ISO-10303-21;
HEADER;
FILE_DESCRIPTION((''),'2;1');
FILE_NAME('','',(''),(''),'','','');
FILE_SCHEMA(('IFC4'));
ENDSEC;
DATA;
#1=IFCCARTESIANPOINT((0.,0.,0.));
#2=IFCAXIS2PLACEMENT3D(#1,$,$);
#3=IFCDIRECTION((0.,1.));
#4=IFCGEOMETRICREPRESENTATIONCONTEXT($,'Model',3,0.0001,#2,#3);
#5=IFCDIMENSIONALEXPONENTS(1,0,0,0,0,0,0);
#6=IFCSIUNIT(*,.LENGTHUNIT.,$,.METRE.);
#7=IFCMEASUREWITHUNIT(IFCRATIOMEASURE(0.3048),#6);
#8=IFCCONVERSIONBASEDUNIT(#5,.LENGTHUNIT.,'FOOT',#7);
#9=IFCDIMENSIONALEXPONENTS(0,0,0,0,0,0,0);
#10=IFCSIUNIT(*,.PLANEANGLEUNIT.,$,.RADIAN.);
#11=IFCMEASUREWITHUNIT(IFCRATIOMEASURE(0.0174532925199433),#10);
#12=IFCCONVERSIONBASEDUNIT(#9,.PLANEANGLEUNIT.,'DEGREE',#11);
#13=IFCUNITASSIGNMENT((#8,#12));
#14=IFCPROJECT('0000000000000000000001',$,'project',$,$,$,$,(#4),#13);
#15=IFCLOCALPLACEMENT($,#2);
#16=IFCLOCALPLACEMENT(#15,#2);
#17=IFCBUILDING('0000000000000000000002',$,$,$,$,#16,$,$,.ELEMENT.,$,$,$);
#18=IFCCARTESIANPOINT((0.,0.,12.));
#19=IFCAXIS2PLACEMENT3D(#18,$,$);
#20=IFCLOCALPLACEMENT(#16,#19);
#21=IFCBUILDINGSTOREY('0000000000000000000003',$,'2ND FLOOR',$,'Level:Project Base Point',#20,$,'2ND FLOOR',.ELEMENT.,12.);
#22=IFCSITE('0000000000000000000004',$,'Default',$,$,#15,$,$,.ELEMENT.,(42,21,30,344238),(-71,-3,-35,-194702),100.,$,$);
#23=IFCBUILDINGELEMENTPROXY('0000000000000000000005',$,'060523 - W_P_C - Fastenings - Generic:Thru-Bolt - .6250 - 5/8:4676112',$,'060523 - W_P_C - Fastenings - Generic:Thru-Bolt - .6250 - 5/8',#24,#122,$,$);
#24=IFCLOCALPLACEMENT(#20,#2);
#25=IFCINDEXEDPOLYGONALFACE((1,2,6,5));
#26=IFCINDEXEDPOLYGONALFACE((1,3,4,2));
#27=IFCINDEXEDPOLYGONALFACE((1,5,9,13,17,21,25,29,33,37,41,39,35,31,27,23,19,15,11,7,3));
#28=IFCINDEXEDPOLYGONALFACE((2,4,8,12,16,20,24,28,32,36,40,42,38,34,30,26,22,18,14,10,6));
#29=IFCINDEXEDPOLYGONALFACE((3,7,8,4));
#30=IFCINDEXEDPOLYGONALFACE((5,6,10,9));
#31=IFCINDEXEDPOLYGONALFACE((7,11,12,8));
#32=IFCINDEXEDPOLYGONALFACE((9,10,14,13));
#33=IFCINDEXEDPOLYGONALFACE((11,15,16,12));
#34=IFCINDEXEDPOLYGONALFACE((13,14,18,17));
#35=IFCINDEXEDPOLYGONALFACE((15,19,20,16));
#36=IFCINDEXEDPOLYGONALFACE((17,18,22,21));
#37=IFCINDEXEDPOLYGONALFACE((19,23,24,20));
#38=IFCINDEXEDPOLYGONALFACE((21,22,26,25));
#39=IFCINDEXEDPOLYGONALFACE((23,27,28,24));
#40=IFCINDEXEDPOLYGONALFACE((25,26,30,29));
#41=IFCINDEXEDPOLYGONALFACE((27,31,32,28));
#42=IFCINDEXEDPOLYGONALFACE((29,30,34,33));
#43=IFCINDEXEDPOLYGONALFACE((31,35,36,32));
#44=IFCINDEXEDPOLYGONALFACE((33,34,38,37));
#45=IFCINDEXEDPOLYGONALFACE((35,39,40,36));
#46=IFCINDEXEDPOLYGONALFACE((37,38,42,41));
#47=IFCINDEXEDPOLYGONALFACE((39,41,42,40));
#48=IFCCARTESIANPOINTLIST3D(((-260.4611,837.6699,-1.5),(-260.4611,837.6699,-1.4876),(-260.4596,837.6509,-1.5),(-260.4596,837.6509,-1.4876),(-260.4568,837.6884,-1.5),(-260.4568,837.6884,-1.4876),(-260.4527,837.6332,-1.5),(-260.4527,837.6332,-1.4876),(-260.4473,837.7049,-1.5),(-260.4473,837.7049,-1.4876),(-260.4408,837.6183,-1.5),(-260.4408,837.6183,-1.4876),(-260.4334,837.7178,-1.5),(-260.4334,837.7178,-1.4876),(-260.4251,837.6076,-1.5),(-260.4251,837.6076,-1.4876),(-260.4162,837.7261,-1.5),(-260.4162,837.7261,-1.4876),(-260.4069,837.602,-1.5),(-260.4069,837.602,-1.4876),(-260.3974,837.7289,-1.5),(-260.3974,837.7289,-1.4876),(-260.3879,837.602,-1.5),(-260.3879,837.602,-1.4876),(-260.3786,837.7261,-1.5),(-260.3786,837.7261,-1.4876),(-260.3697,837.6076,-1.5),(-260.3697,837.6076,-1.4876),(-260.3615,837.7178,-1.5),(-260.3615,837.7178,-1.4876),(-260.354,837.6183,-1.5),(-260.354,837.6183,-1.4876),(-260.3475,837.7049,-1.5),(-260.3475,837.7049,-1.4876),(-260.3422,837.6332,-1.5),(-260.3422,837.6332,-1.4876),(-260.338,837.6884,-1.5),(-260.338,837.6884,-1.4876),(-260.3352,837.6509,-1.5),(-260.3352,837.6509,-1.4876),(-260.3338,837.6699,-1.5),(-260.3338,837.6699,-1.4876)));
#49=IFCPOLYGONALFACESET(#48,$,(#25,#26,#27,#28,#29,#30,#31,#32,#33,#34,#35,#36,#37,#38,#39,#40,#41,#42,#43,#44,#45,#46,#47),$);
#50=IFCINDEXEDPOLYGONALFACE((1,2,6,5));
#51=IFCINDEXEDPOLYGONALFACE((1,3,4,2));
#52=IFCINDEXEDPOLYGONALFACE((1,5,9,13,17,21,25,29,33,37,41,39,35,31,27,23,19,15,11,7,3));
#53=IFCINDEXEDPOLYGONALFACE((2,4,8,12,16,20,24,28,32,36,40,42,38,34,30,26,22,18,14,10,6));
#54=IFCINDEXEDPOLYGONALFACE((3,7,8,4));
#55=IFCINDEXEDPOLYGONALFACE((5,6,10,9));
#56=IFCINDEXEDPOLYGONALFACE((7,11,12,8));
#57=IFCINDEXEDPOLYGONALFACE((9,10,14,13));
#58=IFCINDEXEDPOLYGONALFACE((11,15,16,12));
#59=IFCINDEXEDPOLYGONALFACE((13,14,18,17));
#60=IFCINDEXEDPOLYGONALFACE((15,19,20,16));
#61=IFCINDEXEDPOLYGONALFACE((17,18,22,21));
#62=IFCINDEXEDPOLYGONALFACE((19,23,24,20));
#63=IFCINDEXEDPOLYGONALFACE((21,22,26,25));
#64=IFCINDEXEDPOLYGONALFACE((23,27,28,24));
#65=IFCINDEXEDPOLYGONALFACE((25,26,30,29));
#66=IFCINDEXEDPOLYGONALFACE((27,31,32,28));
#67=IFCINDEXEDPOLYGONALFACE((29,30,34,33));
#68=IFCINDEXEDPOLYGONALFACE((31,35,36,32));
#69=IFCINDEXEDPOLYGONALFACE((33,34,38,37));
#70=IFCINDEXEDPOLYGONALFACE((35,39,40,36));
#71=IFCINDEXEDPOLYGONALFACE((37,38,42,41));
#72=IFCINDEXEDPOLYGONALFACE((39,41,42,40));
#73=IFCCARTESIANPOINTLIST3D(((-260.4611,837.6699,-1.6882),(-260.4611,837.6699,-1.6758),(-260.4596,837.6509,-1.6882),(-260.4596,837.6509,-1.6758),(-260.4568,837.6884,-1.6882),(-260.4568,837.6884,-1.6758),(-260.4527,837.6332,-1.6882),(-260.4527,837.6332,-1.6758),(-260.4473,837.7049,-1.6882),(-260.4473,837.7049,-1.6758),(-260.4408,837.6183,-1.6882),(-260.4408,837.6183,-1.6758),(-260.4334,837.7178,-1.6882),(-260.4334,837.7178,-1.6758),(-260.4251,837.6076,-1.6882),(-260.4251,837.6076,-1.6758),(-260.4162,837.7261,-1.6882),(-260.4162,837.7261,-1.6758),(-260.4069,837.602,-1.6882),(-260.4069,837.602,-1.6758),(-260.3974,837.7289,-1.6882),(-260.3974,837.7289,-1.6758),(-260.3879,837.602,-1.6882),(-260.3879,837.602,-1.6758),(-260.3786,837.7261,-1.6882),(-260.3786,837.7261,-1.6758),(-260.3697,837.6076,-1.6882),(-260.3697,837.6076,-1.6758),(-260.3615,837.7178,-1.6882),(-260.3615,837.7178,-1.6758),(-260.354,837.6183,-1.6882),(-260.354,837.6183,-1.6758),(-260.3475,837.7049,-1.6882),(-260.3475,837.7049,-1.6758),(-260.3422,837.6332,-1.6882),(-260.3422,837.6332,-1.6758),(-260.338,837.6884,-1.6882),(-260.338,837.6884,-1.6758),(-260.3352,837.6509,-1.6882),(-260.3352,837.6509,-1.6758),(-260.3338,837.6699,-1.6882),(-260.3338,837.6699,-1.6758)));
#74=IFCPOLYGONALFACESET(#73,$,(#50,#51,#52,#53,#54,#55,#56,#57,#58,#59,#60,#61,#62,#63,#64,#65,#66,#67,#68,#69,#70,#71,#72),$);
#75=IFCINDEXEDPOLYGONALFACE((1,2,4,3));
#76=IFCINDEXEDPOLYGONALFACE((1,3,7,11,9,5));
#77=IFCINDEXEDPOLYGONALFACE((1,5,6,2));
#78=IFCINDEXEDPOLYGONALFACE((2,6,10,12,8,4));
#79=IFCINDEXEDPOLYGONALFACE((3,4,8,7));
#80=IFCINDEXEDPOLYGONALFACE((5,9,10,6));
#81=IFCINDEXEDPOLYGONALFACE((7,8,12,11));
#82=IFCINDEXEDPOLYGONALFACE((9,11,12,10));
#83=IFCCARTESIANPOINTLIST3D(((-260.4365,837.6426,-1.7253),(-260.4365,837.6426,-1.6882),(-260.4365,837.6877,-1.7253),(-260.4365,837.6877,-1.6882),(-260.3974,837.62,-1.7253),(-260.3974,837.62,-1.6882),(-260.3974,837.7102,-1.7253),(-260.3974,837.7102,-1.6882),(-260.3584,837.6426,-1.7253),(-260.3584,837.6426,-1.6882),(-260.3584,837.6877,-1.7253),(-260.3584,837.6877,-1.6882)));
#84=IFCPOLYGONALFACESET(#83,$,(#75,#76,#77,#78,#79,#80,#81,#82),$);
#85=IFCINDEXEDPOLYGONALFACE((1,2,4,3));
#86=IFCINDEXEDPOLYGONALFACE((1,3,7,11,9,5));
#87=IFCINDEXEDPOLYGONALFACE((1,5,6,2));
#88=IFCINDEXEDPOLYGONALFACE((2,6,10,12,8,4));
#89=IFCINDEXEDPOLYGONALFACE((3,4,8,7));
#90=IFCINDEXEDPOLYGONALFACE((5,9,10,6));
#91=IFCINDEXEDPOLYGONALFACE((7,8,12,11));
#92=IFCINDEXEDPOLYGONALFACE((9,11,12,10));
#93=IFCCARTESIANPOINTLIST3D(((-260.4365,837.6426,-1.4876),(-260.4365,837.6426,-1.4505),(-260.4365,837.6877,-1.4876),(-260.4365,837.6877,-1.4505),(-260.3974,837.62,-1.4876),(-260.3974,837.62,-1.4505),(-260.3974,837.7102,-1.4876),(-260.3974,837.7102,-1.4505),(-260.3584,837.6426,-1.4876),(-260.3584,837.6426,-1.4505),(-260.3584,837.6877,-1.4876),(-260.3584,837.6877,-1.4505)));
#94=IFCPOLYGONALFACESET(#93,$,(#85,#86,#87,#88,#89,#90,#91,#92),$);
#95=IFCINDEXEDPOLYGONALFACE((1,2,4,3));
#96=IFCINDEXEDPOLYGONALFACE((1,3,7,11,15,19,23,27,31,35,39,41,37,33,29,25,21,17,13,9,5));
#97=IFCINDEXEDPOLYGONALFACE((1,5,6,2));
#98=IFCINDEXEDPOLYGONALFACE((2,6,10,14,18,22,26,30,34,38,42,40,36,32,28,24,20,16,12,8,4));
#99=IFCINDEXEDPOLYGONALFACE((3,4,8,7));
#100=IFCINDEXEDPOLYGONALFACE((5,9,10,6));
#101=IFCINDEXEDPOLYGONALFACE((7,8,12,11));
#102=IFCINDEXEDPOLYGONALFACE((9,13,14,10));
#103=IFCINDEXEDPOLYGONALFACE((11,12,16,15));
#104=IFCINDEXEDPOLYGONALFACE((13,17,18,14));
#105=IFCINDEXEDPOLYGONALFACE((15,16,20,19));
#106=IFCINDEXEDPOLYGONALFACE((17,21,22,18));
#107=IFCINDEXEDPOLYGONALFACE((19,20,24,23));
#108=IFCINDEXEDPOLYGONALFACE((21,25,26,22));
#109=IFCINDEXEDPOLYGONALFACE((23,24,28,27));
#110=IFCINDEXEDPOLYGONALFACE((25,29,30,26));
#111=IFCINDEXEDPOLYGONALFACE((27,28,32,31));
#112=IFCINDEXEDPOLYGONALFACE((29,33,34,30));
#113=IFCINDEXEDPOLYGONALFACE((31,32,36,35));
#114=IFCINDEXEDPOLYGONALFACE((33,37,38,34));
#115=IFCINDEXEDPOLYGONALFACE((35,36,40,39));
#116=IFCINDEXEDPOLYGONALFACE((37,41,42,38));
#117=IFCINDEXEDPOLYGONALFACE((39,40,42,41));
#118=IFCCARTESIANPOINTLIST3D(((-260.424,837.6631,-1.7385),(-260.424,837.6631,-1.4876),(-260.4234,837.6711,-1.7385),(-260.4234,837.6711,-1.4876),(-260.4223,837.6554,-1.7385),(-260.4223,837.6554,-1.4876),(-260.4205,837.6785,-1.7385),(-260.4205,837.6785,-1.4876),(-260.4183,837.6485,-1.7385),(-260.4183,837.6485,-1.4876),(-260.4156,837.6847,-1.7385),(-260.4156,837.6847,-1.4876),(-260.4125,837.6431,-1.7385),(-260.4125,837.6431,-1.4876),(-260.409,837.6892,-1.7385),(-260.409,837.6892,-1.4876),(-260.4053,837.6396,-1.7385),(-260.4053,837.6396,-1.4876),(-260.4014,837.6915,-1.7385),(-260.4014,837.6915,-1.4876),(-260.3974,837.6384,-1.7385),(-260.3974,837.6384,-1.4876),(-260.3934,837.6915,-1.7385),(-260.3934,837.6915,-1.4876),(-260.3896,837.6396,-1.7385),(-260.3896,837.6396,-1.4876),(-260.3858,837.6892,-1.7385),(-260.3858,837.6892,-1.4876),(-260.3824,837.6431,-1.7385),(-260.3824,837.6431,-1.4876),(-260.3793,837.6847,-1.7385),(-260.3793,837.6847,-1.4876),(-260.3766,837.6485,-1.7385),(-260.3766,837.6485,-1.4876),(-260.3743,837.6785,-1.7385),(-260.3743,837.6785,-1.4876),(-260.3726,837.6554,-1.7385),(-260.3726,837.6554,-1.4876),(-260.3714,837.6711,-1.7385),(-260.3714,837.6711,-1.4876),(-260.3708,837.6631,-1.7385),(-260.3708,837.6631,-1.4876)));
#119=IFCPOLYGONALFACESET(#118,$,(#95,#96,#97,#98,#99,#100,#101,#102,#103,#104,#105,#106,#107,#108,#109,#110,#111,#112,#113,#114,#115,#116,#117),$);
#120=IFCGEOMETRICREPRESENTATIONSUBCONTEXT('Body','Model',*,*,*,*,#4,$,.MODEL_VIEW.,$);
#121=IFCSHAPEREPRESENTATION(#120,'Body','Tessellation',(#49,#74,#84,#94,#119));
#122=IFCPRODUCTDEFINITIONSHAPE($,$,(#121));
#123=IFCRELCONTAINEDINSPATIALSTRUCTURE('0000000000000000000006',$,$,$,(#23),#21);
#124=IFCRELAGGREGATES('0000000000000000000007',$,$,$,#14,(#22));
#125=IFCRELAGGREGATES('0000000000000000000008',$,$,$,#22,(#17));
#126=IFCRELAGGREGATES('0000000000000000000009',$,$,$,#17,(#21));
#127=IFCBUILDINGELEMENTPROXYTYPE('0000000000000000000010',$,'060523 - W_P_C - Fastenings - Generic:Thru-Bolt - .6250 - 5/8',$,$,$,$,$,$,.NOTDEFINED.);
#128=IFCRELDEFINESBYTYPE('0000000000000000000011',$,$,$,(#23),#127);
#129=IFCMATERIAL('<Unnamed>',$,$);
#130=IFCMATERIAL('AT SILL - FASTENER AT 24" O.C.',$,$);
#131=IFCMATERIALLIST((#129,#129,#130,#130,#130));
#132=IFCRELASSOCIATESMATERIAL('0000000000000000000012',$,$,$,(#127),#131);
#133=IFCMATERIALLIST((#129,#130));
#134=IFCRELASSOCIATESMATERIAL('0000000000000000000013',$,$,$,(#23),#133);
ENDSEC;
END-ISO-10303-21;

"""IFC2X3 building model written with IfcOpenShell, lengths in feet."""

from ifc_helpers import new_model, entity, si_unit, converted_unit, direction, frame, frame_2d, origin, place, context, subcontext, project, spatial, polyline, circle, outline, extrude, source, transform, mapped, material, material_list, type_object, type_shapes, element, save


model = new_model("IFC2X3")

# Units and contexts
model_context = context("Model", 3, precision=0.0001, world=origin(), true_north=direction((0.0, 1.0)))
body_context = subcontext(model_context, "Body", "Model", "MODEL_VIEW")
ifc_project = project(units=[converted_unit("LENGTHUNIT", "FOOT", entity("IfcRatioMeasure", 0.3048), si_unit("LENGTHUNIT", "METRE"), dimensions=[1, 0, 0, 0, 0, 0, 0]), converted_unit("PLANEANGLEUNIT", "DEGREE", entity("IfcRatioMeasure", 0.0174532925199433), si_unit("PLANEANGLEUNIT", "RADIAN"), dimensions=[0, 0, 0, 0, 0, 0, 0])], contexts=[model_context])

# Site, building, storey
site_placement = place(None, origin())
site = spatial("IfcSite", under=ifc_project, at=site_placement, Name="Default", CompositionType="ELEMENT", RefLatitude=(42, 21, 30, 344238), RefLongitude=(-71, -3, -35, -194702), RefElevation=100.0)
building_placement = place(site_placement, origin())
building = spatial("IfcBuilding", under=site, at=building_placement, CompositionType="ELEMENT")
storey_placement = place(building_placement, frame((0.0, 0.0, 12.0)))
storey = spatial("IfcBuildingStorey", under=building, at=storey_placement, Name="2ND FLOOR", ObjectType="Level:Project Base Point", LongName="2ND FLOOR", CompositionType="ELEMENT", Elevation=12.0)

# Building element proxy
ifc_material_1 = material(Name="<Unnamed>")
ifc_material_2 = material(Name="AT SILL - FASTENER AT 24\" O.C.")
ifc_material_list_1 = material_list([ifc_material_1, ifc_material_1, ifc_material_2, ifc_material_2, ifc_material_2])
building_element_proxy_type_1 = type_object("IfcBuildingElementProxyType", Name="060523 - W_P_C - Fastenings - Generic:Thru-Bolt - .6250 - 5/8", PredefinedType="NOTDEFINED", material=ifc_material_list_1)
shared_shape_1 = source(origin(), body_context, "Body", "SweptSolid", [
    extrude(circle(Radius=0.0638, at=frame_2d((0.0, 0.0), x_axis=(1.0, 0.0))), frame((0.0, 0.0, 0.0), z_axis=(0.0, 0.0, 1.0), x_axis=(0.0, 1.0, 0.0)), (0.0, 0.0, 1.0), 0.0124),
    extrude(circle(Radius=0.0638, at=frame_2d((0.0, 0.0), x_axis=(1.0, 0.0))), frame((0.0, 0.0, -0.1882), z_axis=(0.0, 0.0, 1.0), x_axis=(0.0, 1.0, 0.0)), (0.0, 0.0, 1.0), 0.0124),
    extrude(outline(polyline([(-0.0226, -0.0391), (0.0226, -0.0391), (0.0451, 0.0), (0.0226, 0.0391), (-0.0226, 0.0391), (-0.0451, 0.0), (-0.0226, -0.0391)])), frame((0.0, 0.0, -0.2253), z_axis=(0.0, 0.0, 1.0), x_axis=(0.0, -1.0, 0.0)), (0.0, 0.0, 1.0), 0.0371),
    extrude(outline(polyline([(-0.0226, -0.0391), (0.0226, -0.0391), (0.0451, 0.0), (0.0226, 0.0391), (-0.0226, 0.0391), (-0.0451, 0.0), (-0.0226, -0.0391)])), frame((0.0, 0.0, 0.0124), z_axis=(0.0, 0.0, 1.0), x_axis=(0.866025, -0.5, 0.0)), (0.0, 0.0, 1.0), 0.0371),
    extrude(circle(Radius=0.0267, at=frame_2d((0.0, 0.0), x_axis=(1.0, 0.0))), frame((0.0, 0.0, -0.2385), z_axis=(0.0, 0.0, 1.0), x_axis=(0.0, -1.0, 0.0)), (0.0, 0.0, 1.0), 0.2509),
])
type_shapes(building_element_proxy_type_1, [shared_shape_1])
ifc_material_list_2 = material_list([ifc_material_1, ifc_material_2])
proxy_1_placement = place(storey_placement, frame((-260.3974, 837.6651, -1.5)))
element("IfcBuildingElementProxy", 1, at=proxy_1_placement, inside=storey, type_object=building_element_proxy_type_1, material=ifc_material_list_2, Name="060523 - W_P_C - Fastenings - Generic:Thru-Bolt - .6250 - 5/8:4676112", ObjectType="060523 - W_P_C - Fastenings - Generic:Thru-Bolt - .6250 - 5/8", context=body_context, shape_type="MappedRepresentation", body=[
    mapped(shared_shape_1, transform((0.0, 0.0, 0.0), scale=1.0)),
])

save(model, "model.ifc")
